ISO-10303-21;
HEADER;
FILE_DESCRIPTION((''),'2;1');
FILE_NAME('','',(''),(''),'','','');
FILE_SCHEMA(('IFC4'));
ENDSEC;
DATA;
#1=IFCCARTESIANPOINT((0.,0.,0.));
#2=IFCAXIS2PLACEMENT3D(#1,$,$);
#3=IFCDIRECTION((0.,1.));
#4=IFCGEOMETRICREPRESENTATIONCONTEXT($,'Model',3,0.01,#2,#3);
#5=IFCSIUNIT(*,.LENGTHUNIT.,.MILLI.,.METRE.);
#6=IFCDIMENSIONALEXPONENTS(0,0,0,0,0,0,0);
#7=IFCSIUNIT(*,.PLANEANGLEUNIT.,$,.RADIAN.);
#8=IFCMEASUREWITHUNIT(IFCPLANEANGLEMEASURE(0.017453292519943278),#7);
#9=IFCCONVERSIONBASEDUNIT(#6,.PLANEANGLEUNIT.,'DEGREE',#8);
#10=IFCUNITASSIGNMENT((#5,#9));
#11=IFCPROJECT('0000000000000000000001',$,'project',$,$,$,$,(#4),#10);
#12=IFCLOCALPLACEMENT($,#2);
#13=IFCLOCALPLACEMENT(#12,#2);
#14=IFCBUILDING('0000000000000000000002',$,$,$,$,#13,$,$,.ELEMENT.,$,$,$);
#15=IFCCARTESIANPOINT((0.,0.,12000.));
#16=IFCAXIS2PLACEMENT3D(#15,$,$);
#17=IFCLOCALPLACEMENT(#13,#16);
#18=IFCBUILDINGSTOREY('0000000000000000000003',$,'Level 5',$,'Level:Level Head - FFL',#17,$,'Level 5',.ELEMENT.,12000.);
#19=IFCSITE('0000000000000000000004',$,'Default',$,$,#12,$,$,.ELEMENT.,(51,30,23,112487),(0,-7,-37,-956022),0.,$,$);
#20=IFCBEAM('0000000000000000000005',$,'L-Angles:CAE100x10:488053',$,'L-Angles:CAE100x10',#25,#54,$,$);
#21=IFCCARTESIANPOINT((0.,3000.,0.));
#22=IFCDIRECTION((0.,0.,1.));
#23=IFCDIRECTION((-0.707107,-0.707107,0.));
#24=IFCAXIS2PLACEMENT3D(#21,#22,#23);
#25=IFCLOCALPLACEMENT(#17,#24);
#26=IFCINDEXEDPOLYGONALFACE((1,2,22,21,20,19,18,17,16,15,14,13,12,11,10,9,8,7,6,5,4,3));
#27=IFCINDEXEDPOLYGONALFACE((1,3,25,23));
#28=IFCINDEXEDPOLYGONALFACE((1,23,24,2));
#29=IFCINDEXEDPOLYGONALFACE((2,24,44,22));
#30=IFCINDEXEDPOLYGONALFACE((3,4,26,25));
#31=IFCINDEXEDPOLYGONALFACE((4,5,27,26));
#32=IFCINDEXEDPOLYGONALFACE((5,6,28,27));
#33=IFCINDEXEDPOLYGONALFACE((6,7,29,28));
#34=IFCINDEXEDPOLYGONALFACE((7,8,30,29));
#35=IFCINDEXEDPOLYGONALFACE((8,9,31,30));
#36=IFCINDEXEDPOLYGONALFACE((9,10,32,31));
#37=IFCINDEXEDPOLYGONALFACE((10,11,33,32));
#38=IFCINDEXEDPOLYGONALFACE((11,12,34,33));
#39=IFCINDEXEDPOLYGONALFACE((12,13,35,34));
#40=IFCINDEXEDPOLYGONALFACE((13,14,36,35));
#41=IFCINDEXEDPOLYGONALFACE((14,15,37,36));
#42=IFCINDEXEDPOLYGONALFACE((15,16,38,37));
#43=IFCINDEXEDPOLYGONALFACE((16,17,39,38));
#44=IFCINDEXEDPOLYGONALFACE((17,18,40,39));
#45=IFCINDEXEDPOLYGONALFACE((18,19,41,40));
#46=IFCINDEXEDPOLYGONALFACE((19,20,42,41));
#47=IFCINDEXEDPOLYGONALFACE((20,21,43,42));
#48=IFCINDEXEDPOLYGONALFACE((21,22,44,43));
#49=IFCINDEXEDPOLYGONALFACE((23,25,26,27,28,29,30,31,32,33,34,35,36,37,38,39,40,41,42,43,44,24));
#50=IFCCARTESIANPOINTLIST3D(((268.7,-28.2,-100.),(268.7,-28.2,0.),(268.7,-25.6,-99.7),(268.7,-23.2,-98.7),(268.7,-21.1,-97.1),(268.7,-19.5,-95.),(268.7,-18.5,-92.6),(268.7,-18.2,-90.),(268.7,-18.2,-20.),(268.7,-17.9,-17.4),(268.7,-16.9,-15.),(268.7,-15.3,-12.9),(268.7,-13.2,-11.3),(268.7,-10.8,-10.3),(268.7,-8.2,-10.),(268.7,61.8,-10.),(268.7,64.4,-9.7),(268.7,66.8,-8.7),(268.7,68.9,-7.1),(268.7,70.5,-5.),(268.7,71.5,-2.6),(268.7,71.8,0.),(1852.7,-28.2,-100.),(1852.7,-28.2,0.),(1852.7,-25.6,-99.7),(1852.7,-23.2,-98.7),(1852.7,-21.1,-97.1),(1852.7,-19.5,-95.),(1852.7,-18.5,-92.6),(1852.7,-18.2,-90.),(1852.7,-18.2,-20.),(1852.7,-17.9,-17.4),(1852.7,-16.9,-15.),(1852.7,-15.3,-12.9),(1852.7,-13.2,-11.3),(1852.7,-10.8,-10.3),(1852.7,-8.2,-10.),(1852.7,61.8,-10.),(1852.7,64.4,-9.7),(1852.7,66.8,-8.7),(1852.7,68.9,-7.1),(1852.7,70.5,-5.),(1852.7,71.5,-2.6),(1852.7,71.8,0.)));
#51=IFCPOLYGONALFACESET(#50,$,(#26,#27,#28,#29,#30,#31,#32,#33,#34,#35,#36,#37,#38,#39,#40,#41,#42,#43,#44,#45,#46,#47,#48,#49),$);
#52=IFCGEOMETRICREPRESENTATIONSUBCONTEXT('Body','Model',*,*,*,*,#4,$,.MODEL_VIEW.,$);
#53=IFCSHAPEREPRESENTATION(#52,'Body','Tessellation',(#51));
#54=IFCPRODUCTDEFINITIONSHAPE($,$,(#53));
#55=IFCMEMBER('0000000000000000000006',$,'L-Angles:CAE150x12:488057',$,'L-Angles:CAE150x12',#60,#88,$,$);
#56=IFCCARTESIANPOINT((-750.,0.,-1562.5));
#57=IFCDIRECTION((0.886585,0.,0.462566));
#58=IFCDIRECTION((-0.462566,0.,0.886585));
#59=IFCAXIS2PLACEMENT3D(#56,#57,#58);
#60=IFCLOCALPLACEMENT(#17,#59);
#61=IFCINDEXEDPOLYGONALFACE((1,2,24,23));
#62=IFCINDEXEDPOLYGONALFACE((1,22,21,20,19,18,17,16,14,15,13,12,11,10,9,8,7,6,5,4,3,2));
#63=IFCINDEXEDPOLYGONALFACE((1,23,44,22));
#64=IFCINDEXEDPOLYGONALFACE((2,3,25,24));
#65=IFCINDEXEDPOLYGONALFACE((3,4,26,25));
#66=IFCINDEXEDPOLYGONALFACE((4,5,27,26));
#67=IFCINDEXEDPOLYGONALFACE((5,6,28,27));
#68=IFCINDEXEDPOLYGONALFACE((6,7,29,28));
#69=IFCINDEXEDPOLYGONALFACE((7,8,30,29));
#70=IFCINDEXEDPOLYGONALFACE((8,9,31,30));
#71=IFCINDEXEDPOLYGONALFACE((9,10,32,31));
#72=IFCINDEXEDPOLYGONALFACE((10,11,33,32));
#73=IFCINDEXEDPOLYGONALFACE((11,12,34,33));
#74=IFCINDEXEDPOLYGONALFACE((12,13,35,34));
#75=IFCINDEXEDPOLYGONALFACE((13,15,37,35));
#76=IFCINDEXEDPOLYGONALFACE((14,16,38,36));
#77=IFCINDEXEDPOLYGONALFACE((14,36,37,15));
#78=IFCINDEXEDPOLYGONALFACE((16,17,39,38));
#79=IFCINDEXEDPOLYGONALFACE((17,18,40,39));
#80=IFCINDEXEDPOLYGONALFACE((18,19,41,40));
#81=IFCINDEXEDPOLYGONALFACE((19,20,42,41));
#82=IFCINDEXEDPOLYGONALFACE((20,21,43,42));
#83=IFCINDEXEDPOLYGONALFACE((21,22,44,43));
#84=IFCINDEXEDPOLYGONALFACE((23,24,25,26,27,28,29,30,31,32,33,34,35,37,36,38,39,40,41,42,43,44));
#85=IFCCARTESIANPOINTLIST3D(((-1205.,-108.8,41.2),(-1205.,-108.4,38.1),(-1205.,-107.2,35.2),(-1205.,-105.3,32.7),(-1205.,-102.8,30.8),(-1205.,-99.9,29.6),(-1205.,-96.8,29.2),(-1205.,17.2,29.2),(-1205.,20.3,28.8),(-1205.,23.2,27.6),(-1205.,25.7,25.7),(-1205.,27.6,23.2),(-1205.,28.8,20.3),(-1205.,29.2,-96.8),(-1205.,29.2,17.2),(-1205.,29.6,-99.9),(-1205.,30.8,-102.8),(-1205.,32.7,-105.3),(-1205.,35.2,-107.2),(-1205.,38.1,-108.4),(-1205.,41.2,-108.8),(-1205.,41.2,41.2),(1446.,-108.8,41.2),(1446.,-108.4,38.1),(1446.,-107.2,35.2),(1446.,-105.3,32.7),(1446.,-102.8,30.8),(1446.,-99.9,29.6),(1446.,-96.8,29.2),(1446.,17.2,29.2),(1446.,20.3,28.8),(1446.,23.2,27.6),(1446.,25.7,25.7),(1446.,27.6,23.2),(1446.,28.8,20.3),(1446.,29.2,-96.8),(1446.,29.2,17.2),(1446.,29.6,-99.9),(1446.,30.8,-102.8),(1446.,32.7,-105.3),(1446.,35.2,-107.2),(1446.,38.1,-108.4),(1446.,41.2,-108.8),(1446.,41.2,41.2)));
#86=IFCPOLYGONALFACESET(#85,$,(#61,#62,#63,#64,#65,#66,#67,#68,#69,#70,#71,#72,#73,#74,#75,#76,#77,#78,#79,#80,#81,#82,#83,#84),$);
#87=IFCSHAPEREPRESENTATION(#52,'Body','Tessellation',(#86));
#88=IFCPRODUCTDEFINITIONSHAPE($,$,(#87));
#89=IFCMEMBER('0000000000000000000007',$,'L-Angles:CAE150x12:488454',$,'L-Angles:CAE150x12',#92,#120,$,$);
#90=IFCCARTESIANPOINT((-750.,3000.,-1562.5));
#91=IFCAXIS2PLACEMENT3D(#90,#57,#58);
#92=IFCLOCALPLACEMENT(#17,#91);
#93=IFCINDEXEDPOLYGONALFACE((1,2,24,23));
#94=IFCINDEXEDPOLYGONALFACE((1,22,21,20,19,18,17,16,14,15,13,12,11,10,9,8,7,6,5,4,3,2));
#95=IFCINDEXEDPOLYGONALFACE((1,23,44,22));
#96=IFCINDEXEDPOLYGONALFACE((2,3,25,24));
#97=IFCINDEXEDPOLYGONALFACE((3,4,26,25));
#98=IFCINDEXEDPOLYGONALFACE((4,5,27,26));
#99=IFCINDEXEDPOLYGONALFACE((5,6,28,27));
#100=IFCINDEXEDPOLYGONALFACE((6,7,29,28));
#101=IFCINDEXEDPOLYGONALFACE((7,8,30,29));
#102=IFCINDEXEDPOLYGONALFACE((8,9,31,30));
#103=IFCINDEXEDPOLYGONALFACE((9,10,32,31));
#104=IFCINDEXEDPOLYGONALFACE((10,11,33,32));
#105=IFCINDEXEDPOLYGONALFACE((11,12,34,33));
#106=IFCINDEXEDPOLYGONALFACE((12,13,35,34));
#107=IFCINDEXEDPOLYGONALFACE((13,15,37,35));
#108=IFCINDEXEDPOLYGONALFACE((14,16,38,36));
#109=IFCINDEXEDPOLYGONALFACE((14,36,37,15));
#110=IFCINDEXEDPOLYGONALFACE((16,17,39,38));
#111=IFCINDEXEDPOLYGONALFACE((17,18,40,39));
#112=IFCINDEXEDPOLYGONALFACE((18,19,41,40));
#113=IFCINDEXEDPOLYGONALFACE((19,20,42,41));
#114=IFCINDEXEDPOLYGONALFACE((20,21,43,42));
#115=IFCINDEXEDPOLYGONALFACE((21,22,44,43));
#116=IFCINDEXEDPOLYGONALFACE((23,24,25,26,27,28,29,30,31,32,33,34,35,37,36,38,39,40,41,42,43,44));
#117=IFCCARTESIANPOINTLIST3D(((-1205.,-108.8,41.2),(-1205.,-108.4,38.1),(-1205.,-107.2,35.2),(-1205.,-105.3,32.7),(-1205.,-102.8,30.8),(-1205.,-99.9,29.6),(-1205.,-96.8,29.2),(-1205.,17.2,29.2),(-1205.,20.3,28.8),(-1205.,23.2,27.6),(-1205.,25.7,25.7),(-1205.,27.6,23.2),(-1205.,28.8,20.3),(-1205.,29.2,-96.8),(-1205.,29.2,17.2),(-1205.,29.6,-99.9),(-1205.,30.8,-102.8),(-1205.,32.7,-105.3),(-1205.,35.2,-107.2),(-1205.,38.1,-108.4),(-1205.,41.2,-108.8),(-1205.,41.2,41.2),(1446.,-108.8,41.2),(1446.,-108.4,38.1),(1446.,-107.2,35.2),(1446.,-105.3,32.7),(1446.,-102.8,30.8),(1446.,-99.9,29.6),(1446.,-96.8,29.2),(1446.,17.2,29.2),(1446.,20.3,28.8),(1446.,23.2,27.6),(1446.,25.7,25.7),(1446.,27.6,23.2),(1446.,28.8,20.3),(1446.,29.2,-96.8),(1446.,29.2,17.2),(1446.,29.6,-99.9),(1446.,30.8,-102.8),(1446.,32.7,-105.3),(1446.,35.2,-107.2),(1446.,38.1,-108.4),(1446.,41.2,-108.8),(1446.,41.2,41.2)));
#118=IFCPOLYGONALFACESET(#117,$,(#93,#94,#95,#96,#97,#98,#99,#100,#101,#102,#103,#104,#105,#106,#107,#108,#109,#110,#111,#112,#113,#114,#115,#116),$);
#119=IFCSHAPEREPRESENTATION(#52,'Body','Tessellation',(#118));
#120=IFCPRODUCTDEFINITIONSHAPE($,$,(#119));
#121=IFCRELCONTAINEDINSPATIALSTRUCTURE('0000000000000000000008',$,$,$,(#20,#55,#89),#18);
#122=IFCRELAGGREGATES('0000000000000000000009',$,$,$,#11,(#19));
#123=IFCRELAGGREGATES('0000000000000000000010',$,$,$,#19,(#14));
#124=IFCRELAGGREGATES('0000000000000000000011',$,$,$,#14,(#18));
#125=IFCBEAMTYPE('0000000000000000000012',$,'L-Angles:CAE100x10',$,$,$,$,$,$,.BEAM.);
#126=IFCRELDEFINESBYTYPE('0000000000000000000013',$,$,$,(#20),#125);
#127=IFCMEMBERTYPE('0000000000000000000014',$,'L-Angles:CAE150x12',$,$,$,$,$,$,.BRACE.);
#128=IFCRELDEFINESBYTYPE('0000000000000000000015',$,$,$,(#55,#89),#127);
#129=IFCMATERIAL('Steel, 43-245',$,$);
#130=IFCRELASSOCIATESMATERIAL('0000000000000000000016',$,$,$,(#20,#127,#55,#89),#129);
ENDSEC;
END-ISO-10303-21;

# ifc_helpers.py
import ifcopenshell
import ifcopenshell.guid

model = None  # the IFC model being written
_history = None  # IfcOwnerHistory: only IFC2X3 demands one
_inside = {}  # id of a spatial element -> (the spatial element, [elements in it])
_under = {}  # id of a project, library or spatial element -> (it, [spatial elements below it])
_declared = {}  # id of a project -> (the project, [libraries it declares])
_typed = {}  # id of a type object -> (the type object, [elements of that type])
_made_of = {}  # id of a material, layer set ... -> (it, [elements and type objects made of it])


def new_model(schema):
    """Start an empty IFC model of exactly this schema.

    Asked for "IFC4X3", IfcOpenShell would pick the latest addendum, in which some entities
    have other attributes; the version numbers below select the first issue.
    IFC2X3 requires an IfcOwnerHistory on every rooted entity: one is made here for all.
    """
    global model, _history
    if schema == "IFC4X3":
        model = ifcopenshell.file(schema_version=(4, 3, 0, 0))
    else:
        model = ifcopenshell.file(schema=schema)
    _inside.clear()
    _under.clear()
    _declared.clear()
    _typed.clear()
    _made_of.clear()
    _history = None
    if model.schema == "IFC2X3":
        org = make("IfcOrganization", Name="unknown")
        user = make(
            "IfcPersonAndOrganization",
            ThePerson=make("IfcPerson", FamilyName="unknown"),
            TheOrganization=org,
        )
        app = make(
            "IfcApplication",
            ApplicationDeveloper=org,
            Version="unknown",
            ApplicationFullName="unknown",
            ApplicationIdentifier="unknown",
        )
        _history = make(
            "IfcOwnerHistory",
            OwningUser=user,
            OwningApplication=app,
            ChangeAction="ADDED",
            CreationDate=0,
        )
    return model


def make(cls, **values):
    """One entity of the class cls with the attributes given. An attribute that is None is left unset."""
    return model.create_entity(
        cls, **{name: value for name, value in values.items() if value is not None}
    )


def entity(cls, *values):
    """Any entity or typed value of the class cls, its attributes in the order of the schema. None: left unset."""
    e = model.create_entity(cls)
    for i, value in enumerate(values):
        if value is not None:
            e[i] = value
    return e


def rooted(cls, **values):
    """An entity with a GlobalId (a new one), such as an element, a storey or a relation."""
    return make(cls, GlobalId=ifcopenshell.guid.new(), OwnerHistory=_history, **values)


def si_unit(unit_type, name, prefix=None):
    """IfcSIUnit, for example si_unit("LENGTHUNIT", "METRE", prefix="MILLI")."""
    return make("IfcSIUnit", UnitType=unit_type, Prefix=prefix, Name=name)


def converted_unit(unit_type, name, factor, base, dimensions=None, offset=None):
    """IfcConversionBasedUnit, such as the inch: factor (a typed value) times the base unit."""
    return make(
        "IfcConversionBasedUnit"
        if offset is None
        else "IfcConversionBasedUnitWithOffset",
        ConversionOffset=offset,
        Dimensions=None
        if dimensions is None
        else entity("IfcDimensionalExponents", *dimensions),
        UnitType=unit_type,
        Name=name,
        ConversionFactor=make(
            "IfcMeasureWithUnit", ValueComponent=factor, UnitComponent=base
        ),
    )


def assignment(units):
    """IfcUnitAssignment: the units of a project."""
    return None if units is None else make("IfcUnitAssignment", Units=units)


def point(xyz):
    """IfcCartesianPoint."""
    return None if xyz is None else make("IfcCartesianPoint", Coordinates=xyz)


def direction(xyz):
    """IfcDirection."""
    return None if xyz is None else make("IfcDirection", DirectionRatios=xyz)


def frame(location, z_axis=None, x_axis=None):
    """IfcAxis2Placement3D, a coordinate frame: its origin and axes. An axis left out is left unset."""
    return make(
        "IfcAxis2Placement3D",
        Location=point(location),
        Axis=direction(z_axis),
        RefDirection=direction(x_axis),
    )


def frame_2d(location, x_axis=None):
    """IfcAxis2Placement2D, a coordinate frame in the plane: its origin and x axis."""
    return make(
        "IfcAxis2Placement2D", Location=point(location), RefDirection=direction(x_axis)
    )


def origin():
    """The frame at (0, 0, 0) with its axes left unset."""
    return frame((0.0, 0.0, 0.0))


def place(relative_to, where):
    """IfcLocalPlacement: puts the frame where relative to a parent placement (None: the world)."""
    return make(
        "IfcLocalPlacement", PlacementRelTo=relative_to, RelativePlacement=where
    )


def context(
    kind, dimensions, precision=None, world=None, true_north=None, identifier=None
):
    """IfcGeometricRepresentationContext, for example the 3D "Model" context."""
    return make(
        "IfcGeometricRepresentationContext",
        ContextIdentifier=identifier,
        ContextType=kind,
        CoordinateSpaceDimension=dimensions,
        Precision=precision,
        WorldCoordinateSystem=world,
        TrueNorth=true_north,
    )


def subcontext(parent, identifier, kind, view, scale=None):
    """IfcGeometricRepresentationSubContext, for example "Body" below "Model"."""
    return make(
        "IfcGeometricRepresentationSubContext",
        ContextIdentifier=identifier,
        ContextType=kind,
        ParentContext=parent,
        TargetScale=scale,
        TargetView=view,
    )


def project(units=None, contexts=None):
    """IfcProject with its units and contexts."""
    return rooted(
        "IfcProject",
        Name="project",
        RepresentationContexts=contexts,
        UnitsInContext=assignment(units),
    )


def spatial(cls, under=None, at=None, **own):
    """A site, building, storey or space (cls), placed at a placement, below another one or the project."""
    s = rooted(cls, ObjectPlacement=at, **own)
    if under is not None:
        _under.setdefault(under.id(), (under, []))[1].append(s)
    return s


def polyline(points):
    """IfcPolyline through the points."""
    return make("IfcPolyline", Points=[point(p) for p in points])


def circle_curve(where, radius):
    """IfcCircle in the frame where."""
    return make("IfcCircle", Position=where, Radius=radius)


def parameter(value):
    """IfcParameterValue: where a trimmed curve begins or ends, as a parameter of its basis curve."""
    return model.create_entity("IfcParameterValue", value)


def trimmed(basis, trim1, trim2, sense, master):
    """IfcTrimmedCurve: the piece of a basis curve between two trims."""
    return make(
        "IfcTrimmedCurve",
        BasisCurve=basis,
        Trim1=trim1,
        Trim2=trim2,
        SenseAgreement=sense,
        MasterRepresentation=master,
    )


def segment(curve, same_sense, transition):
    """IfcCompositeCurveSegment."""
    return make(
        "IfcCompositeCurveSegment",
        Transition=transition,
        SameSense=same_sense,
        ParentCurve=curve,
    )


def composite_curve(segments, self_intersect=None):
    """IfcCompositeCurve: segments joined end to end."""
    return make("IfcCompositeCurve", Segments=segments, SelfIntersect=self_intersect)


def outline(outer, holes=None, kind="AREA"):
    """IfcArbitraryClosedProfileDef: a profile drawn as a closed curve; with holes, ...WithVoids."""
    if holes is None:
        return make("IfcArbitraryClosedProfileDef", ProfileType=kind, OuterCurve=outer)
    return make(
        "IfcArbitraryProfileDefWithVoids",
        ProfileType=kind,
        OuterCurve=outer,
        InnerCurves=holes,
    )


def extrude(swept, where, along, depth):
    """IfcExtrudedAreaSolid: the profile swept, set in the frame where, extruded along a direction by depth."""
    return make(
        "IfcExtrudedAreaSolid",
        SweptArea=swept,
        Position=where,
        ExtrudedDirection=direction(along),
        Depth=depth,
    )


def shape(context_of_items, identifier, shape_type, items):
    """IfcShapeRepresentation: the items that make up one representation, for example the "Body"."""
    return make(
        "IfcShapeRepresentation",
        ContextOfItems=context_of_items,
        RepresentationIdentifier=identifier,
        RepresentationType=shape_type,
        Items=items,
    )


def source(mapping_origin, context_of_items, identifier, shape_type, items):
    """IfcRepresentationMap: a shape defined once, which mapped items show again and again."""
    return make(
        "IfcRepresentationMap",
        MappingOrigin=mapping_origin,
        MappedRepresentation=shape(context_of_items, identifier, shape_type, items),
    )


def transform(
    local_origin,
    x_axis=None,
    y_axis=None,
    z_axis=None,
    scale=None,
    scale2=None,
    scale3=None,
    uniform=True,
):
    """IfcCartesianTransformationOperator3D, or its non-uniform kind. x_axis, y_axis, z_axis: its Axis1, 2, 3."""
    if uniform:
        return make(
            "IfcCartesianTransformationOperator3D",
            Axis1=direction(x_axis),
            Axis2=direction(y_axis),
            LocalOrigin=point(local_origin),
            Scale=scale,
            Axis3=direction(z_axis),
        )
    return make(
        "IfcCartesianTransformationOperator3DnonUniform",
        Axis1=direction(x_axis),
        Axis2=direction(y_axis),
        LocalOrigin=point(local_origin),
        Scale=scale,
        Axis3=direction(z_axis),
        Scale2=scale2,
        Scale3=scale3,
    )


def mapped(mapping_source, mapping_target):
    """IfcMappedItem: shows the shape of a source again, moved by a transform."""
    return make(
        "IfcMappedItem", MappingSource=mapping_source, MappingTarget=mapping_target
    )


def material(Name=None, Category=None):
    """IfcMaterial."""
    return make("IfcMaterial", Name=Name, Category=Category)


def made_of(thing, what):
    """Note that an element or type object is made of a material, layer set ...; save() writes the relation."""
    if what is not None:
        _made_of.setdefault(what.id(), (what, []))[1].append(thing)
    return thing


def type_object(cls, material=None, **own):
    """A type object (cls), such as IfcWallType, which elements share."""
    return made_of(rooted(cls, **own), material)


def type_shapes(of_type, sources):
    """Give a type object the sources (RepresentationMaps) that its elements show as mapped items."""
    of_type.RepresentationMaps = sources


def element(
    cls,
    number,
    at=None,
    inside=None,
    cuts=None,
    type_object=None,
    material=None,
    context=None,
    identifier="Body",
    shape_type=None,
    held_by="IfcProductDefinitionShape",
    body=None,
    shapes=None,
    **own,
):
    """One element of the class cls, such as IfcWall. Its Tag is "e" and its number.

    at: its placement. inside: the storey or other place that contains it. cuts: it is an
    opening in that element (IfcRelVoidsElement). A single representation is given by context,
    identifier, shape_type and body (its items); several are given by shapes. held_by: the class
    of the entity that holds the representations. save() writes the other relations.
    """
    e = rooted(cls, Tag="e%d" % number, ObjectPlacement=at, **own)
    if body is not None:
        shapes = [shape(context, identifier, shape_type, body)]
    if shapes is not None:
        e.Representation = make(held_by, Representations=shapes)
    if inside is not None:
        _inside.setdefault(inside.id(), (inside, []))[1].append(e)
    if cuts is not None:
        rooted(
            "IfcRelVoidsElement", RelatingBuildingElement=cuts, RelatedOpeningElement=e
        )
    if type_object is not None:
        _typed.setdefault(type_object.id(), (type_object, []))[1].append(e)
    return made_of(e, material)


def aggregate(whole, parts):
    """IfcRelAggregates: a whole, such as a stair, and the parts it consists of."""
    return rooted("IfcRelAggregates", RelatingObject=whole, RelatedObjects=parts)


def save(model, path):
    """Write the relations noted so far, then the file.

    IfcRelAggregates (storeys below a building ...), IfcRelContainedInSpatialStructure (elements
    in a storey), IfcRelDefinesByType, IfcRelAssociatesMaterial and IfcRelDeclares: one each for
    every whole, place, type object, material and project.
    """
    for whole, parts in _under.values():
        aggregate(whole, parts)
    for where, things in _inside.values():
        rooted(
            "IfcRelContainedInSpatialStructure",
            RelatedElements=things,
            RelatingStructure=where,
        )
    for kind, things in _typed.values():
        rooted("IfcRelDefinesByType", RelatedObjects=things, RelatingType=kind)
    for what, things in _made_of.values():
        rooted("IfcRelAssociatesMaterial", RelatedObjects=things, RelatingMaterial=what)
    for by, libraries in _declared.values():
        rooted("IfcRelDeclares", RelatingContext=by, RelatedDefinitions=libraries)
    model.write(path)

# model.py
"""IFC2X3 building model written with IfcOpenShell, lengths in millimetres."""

from ifc_helpers import new_model, entity, si_unit, converted_unit, direction, frame, frame_2d, origin, place, context, subcontext, project, spatial, polyline, circle_curve, parameter, trimmed, segment, composite_curve, outline, extrude, source, transform, mapped, material, type_object, type_shapes, element, save


model = new_model("IFC2X3")

# Units and contexts
model_context = context("Model", 3, precision=0.01, world=origin(), true_north=direction((0.0, 1.0)))
body_context = subcontext(model_context, "Body", "Model", "MODEL_VIEW")
ifc_project = project(units=[si_unit("LENGTHUNIT", "METRE", prefix="MILLI"), converted_unit("PLANEANGLEUNIT", "DEGREE", entity("IfcPlaneAngleMeasure", 0.017453292519943278), si_unit("PLANEANGLEUNIT", "RADIAN"), dimensions=[0, 0, 0, 0, 0, 0, 0])], contexts=[model_context])

# Site, building, storey
site_placement = place(None, origin())
site = spatial("IfcSite", under=ifc_project, at=site_placement, Name="Default", CompositionType="ELEMENT", RefLatitude=(51, 30, 23, 112487), RefLongitude=(0, -7, -37, -956022), RefElevation=0.0)
building_placement = place(site_placement, origin())
building = spatial("IfcBuilding", under=site, at=building_placement, CompositionType="ELEMENT")
storey_placement = place(building_placement, frame((0.0, 0.0, 12000.0)))
storey = spatial("IfcBuildingStorey", under=building, at=storey_placement, Name="Level 5", ObjectType="Level:Level Head - FFL", LongName="Level 5", CompositionType="ELEMENT", Elevation=12000.0)

# Beam
ifc_material = material(Name="Steel, 43-245")
beam_type_1 = type_object("IfcBeamType", Name="L-Angles:CAE100x10", PredefinedType="BEAM")
beam_1_placement = place(storey_placement, frame((0.0, 3000.0, 0.0), z_axis=(0.0, 0.0, 1.0), x_axis=(-0.707107, -0.707107, 0.0)))
element("IfcBeam", 1, at=beam_1_placement, inside=storey, type_object=beam_type_1, material=ifc_material, Name="L-Angles:CAE100x10:488053", ObjectType="L-Angles:CAE100x10", context=body_context, shape_type="SweptSolid", body=[
    extrude(outline(composite_curve([segment(polyline([(-32.9, -32.9), (67.1, -32.9)]), True, "CONTINUOUS"), segment(trimmed(circle_curve(frame_2d((57.1, -32.9), x_axis=(1.0, 0.0)), 10.0), [parameter(0.0)], [parameter(90.0)], True, "PARAMETER"), True, "CONTINUOUS"), segment(polyline([(57.1, -22.9), (-12.9, -22.9)]), True, "CONTINUOUS"), segment(trimmed(circle_curve(frame_2d((-12.9, -12.9), x_axis=(0.0, -1.0)), 10.0), [parameter(270.0)], [parameter(0.0)], True, "PARAMETER"), False, "CONTINUOUS"), segment(polyline([(-22.9, -12.9), (-22.9, 57.1)]), True, "CONTINUOUS"), segment(trimmed(circle_curve(frame_2d((-32.9, 57.1), x_axis=(1.0, 0.0)), 10.0), [parameter(0.0)], [parameter(90.0)], True, "PARAMETER"), True, "CONTINUOUS"), segment(polyline([(-32.9, 67.1), (-32.9, -32.9)]), True, "CONTINUOUS")], self_intersect=False)), frame((268.7, 4.7, -32.9), z_axis=(1.0, 0.0, 0.0), x_axis=(0.0, 0.0, -1.0)), (0.0, 0.0, 1.0), 1584.0),
])

# Members
member_type_1 = type_object("IfcMemberType", Name="L-Angles:CAE150x12", PredefinedType="BRACE", material=ifc_material)
shared_shape_1 = source(origin(), body_context, "Body", "SweptSolid", [
    extrude(outline(composite_curve([segment(polyline([(-102.0, -48.0), (48.0, -48.0)]), True, "CONTINUOUS"), segment(polyline([(48.0, -48.0), (48.0, 102.0)]), True, "CONTINUOUS"), segment(trimmed(circle_curve(frame_2d((48.0, 90.0), x_axis=(0.0, 1.0)), 12.0), [parameter(0.0)], [parameter(90.0)], True, "PARAMETER"), True, "CONTINUOUS"), segment(polyline([(36.0, 90.0), (36.0, -24.0)]), True, "CONTINUOUS"), segment(trimmed(circle_curve(frame_2d((24.0, -24.0), x_axis=(1.0, 0.0)), 12.0), [parameter(270.0)], [parameter(0.0)], True, "PARAMETER"), False, "CONTINUOUS"), segment(polyline([(24.0, -36.0), (-90.0, -36.0)]), True, "CONTINUOUS"), segment(trimmed(circle_curve(frame_2d((-90.0, -48.0), x_axis=(0.0, 1.0)), 12.0), [parameter(0.0)], [parameter(90.0)], True, "PARAMETER"), True, "CONTINUOUS")], self_intersect=False)), frame((-1205.0, -6.8, -6.8), z_axis=(1.0, 0.0, 0.0), x_axis=(0.0, 0.0, 1.0)), (0.0, 0.0, 1.0), 2651.0),
])
type_shapes(member_type_1, [shared_shape_1])
for number, where, z_axis, x_axis, name in (
    (2, (-750.0, 0.0, -1562.5), (0.886585, 0.0, 0.462566), (-0.462566, 0.0, 0.886585), "L-Angles:CAE150x12:488057"),
    (3, (-750.0, 3000.0, -1562.5), (0.886585, 0.0, 0.462566), (-0.462566, 0.0, 0.886585), "L-Angles:CAE150x12:488454"),
):
    element("IfcMember", number, at=place(storey_placement, frame(where, z_axis=z_axis, x_axis=x_axis)), inside=storey, type_object=member_type_1, material=ifc_material, Name=name, ObjectType="L-Angles:CAE150x12", context=body_context, shape_type="MappedRepresentation", body=[
        mapped(shared_shape_1, transform((0.0, 0.0, 0.0), scale=1.0)),
    ])

save(model, "model.ifc")
